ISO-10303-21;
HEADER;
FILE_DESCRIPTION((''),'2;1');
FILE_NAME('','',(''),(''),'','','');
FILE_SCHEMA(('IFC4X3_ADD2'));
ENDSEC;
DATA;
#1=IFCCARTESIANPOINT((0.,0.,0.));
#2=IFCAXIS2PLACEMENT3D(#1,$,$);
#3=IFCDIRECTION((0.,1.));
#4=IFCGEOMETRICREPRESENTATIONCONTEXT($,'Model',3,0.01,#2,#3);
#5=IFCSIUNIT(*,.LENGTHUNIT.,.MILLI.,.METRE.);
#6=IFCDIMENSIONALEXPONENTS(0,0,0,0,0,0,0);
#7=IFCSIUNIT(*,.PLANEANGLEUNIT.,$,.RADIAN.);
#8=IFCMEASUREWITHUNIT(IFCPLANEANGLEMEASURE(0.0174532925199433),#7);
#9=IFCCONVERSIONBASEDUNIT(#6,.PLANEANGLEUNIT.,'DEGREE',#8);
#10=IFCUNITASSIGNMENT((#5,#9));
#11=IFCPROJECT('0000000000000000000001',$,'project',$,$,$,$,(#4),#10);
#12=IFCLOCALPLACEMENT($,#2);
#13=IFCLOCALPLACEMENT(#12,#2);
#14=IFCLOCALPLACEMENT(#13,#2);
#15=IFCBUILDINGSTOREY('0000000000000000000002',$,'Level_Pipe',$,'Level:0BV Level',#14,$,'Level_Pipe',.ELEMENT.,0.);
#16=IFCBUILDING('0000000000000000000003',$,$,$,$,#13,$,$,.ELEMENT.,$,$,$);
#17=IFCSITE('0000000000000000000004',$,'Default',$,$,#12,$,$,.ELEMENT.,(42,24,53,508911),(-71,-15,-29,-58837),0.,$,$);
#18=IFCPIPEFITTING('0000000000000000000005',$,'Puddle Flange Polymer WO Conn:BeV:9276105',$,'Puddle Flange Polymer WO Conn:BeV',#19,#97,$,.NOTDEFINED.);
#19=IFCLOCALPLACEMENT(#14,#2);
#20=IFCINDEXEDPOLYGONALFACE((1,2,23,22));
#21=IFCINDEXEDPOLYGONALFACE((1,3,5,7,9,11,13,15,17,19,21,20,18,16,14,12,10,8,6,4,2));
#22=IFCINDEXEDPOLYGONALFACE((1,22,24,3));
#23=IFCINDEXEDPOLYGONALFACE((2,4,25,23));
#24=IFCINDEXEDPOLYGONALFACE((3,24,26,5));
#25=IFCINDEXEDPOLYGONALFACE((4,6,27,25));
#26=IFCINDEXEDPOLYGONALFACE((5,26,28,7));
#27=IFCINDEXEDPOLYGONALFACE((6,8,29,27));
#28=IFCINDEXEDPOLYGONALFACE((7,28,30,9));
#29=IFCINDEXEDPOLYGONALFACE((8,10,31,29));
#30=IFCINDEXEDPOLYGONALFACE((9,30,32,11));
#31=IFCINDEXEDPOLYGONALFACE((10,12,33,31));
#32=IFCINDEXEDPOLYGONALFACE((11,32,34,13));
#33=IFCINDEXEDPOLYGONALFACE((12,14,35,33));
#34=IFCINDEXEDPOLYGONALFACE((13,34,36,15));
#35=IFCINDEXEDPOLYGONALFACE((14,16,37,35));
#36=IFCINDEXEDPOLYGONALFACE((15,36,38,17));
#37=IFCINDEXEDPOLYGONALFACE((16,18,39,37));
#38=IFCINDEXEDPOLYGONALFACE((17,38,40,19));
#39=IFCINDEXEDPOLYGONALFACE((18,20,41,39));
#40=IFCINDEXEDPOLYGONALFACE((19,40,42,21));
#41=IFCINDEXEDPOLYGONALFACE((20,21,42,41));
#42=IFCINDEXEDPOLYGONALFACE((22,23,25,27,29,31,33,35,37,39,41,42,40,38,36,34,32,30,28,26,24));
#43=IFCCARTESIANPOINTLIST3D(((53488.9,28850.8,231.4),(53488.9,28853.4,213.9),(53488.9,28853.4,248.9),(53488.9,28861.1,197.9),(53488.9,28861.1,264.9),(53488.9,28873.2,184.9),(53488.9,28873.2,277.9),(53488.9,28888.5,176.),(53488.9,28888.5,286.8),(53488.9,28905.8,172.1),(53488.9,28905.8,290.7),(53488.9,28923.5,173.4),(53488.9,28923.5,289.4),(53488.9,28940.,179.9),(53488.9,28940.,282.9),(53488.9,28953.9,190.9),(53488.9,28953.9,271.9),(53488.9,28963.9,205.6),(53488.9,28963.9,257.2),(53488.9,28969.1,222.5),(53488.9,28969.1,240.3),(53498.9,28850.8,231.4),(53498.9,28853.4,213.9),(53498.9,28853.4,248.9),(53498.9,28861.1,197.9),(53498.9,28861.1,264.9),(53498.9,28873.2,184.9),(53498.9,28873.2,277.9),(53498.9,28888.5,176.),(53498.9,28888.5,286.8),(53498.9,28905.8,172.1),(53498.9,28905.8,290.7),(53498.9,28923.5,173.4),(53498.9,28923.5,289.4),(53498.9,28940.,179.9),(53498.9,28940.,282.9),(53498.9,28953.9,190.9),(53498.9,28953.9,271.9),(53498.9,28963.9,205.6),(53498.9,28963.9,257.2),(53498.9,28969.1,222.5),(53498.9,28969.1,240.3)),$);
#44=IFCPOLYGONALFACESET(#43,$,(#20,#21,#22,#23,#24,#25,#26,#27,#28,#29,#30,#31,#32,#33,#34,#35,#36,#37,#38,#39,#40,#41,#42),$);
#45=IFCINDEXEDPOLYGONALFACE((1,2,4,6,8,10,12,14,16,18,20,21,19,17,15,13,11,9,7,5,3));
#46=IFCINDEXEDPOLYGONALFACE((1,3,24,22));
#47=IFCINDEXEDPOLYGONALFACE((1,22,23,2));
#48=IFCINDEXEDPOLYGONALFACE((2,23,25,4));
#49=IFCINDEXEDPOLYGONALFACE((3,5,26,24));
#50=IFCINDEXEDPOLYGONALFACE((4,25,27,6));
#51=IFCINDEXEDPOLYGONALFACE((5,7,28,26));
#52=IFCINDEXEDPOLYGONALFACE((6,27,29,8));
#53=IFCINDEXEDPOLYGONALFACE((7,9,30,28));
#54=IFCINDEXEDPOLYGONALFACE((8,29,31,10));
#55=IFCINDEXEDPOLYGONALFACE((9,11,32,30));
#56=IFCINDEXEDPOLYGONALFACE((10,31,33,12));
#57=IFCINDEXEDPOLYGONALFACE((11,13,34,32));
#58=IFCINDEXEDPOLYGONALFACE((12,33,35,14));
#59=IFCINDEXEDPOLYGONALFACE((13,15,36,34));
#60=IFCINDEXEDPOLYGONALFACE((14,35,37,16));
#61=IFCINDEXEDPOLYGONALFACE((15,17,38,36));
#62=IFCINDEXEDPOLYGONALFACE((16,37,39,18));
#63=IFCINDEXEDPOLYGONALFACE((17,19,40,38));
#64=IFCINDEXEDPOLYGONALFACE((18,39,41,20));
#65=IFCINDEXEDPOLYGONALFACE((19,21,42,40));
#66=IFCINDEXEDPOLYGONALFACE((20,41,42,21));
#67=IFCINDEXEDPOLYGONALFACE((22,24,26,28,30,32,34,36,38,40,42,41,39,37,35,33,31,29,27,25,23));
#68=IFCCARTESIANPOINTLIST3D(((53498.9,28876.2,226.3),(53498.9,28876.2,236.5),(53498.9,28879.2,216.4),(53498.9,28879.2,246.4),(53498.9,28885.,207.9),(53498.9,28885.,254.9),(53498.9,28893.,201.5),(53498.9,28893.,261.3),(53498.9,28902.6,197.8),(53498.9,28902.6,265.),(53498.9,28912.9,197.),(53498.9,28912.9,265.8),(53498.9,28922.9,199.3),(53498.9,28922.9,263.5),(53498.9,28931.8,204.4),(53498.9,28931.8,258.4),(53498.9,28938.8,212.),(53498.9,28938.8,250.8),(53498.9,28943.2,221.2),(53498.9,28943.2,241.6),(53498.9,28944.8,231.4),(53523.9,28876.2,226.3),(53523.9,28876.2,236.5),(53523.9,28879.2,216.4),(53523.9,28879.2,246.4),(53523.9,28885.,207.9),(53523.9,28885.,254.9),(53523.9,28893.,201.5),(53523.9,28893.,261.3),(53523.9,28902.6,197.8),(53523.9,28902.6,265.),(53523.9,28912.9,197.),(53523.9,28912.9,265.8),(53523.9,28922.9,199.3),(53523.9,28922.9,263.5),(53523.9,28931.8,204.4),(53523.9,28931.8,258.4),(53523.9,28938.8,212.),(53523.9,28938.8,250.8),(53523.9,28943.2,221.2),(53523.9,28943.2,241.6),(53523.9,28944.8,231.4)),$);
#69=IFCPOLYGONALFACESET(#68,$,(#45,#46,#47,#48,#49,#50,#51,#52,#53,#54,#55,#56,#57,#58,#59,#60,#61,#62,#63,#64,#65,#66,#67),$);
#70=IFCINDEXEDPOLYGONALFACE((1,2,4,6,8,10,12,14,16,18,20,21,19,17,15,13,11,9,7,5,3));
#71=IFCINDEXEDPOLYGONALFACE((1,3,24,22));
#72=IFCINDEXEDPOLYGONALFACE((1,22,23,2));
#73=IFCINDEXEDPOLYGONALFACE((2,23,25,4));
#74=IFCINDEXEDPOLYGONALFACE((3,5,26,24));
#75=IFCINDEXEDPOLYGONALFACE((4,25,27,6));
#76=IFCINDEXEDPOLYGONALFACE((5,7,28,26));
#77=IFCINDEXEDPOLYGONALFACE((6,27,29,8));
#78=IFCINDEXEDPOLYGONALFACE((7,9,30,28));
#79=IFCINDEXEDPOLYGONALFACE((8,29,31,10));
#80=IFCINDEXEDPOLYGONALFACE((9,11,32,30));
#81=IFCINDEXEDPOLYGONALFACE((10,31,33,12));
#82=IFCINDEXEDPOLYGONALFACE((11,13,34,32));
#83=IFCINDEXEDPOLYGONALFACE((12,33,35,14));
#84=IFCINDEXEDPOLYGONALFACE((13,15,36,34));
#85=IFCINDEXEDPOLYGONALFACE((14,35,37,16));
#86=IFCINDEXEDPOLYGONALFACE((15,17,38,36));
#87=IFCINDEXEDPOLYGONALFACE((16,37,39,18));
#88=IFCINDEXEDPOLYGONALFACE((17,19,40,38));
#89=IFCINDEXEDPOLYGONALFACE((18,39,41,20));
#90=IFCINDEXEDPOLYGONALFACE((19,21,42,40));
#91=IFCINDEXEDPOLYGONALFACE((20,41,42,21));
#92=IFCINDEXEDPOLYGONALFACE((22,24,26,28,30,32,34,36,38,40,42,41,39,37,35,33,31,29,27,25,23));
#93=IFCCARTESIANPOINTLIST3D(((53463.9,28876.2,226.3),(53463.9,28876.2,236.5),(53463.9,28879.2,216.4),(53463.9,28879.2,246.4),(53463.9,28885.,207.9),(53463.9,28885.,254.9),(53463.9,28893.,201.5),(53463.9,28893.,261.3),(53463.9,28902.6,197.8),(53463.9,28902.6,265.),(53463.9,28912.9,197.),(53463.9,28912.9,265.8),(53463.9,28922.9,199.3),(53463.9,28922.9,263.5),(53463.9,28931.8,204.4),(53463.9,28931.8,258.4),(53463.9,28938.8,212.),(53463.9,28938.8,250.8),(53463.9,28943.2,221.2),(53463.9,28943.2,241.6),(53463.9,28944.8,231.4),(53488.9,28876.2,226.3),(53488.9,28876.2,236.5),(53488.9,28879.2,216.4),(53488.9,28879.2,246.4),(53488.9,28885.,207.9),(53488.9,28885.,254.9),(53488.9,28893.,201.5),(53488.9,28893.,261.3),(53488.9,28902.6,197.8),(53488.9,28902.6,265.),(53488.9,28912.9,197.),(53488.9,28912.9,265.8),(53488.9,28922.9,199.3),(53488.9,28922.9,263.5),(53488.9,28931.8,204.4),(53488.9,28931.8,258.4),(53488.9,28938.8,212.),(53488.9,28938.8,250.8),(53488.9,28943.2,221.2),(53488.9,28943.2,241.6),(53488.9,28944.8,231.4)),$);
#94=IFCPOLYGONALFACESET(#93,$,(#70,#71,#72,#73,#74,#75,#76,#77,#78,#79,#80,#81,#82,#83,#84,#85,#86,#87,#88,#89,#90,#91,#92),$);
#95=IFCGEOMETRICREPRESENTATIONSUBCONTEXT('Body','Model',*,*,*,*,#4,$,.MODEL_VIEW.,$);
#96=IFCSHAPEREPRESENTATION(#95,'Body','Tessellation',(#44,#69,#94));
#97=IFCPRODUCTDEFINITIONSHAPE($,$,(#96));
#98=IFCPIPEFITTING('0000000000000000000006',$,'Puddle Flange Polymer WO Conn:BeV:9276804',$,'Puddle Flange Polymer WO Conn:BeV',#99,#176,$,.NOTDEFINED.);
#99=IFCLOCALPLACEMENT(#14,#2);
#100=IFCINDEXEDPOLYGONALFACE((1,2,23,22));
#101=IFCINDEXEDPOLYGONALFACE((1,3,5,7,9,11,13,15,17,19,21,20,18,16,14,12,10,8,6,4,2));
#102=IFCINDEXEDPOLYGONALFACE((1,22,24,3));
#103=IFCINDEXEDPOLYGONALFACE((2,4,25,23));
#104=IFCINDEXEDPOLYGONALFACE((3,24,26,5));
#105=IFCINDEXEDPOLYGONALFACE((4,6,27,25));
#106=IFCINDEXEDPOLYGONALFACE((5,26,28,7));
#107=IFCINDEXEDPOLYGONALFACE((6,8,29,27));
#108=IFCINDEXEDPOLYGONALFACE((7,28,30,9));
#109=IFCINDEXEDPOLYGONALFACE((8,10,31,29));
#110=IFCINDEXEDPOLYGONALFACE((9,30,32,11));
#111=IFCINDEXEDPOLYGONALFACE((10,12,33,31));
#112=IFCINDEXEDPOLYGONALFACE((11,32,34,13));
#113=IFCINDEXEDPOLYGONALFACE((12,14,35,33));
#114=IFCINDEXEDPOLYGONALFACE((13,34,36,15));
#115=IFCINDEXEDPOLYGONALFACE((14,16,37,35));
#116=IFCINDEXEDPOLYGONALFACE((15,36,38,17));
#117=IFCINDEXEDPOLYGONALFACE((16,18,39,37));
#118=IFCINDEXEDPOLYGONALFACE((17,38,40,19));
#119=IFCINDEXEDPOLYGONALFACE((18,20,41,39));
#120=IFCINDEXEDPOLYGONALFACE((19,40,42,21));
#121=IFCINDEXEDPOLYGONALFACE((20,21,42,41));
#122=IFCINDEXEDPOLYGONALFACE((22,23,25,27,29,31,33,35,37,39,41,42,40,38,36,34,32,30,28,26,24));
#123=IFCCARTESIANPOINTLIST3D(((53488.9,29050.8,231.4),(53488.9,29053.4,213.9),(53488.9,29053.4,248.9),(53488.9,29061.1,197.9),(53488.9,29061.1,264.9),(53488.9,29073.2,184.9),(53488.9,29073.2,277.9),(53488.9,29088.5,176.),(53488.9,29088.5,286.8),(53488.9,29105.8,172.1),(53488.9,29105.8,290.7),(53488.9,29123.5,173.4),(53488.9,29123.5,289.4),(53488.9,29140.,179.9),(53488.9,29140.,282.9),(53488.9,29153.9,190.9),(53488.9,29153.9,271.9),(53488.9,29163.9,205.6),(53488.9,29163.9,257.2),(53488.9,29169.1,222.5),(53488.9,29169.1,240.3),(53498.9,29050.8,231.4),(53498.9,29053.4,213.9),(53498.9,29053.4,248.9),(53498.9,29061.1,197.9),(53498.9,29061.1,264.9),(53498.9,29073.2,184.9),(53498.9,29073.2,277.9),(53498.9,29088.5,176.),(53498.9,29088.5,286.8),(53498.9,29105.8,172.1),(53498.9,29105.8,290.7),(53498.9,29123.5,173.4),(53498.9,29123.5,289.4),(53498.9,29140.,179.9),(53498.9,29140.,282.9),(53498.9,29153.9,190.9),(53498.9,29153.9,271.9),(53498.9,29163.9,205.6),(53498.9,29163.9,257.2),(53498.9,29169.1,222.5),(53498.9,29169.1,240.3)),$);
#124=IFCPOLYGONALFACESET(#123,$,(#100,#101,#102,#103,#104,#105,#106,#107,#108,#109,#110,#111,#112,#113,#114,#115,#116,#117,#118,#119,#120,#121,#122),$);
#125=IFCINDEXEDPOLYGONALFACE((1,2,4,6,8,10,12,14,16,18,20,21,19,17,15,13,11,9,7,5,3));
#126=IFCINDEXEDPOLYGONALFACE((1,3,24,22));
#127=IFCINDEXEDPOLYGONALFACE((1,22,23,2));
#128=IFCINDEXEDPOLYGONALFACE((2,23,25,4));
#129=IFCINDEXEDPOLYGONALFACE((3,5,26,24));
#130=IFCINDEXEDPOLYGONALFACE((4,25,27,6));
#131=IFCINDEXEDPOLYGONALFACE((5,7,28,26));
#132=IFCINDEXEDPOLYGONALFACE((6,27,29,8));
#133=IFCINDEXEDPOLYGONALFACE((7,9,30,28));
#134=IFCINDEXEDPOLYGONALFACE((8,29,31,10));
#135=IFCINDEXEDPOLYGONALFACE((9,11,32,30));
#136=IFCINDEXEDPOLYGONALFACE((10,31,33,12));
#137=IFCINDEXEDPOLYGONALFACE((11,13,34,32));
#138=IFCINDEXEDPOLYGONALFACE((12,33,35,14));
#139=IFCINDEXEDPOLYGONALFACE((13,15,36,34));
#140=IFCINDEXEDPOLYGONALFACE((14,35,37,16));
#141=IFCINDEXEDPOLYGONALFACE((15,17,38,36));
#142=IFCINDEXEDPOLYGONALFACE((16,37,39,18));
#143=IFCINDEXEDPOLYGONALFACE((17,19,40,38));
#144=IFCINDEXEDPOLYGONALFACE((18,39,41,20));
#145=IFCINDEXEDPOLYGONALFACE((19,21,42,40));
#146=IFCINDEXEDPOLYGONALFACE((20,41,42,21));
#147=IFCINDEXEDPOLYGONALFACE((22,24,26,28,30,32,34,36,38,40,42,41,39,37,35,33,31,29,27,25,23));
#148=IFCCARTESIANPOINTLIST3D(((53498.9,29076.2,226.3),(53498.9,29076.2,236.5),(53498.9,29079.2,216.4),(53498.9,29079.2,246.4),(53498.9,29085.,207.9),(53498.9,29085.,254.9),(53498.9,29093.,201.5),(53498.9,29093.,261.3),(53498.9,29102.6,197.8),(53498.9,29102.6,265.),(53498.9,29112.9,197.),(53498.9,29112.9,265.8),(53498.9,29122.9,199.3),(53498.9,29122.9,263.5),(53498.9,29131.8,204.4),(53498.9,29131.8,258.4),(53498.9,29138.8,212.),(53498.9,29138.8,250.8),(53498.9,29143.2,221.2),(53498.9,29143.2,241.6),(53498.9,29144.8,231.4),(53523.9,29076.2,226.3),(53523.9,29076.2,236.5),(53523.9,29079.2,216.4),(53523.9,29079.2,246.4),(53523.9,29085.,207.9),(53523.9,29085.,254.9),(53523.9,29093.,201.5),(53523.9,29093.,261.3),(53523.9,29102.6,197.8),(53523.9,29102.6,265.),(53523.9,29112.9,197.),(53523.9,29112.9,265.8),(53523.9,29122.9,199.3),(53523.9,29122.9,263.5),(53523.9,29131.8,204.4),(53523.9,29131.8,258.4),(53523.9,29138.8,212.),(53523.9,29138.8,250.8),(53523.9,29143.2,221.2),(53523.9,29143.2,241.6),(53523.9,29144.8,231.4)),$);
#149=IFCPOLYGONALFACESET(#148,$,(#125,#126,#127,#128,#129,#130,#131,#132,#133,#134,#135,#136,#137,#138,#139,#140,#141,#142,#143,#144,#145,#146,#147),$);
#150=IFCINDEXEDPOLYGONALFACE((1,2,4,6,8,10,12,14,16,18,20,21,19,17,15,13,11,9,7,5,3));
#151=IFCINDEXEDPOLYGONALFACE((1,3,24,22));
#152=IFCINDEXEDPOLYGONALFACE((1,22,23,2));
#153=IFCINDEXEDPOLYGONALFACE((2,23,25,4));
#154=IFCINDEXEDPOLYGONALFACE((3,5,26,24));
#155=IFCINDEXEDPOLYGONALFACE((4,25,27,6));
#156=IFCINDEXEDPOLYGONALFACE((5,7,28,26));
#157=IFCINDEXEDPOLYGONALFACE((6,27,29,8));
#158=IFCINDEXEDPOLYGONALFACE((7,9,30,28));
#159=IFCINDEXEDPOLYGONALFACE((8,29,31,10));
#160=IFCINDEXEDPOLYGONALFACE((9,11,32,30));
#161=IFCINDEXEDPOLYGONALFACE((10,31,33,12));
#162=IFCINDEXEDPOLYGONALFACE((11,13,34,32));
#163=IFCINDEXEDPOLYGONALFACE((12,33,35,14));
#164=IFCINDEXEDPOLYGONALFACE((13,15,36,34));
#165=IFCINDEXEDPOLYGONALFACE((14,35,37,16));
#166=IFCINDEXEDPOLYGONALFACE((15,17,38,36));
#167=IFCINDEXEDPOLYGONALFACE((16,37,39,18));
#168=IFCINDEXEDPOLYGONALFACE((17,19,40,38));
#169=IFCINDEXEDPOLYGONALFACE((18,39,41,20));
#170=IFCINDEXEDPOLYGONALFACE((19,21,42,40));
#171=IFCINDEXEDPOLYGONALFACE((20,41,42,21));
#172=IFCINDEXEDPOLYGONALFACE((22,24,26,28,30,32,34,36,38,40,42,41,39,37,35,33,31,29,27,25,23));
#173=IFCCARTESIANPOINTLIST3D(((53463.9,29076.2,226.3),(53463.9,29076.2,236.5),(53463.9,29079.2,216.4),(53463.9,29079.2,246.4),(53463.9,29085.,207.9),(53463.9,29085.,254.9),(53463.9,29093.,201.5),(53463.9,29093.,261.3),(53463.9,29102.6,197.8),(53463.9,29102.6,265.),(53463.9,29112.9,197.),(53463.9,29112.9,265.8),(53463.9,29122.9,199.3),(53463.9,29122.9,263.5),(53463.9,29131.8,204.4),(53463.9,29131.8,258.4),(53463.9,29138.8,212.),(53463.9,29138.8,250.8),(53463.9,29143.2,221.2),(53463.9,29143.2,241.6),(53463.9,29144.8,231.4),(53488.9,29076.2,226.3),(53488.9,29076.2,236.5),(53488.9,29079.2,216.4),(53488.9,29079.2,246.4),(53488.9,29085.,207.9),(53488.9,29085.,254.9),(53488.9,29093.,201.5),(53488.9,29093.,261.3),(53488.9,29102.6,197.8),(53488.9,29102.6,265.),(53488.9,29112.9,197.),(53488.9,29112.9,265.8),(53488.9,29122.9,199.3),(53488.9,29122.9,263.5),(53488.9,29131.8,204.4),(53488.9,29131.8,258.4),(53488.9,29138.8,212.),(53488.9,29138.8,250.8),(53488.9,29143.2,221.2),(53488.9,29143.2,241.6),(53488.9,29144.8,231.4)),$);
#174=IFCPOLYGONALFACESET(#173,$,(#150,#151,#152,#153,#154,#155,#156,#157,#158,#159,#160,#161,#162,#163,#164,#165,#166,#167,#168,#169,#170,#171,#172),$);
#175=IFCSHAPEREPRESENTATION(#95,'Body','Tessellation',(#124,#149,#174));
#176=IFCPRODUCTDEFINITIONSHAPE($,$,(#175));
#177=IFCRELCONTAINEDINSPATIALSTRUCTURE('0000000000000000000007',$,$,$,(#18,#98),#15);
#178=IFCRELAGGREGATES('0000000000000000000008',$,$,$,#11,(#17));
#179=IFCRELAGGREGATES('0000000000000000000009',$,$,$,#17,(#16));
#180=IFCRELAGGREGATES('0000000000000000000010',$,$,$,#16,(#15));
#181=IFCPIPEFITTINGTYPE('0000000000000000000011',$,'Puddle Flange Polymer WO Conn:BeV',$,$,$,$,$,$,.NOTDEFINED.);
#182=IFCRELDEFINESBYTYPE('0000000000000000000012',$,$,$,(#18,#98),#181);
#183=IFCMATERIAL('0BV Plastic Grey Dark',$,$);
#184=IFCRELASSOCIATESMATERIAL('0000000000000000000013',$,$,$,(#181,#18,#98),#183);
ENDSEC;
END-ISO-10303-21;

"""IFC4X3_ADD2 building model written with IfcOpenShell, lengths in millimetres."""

from ifc_helpers import new_model, entity, si_unit, converted_unit, direction, frame, frame_2d, origin, place, context, subcontext, project, spatial, circle, extrude, source, transform, mapped, material, type_object, type_shapes, element, save


model = new_model("IFC4X3_ADD2")

# Units and contexts
model_context = context("Model", 3, precision=0.01, world=origin(), true_north=direction((0.0, 1.0)))
body_context = subcontext(model_context, "Body", "Model", "MODEL_VIEW")
ifc_project = project(units=[si_unit("LENGTHUNIT", "METRE", prefix="MILLI"), converted_unit("PLANEANGLEUNIT", "DEGREE", entity("IfcPlaneAngleMeasure", 0.0174532925199433), si_unit("PLANEANGLEUNIT", "RADIAN"), dimensions=[0, 0, 0, 0, 0, 0, 0])], contexts=[model_context])

# Site, building, storey
site_placement = place(None, origin())
site = spatial("IfcSite", under=ifc_project, at=site_placement, Name="Default", CompositionType="ELEMENT", RefLatitude=(42, 24, 53, 508911), RefLongitude=(-71, -15, -29, -58837), RefElevation=0.0)
building_placement = place(site_placement, origin())
building = spatial("IfcBuilding", under=site, at=building_placement, CompositionType="ELEMENT")
storey_placement = place(building_placement, origin())
storey = spatial("IfcBuildingStorey", under=building, at=storey_placement, Name="Level_Pipe", ObjectType="Level:0BV Level", LongName="Level_Pipe", CompositionType="ELEMENT", Elevation=0.0)

# Pipe fittings
ifc_material_1 = material(Name="0BV Plastic Grey Dark")
pipe_fitting_type_1 = type_object("IfcPipeFittingType", Name="Puddle Flange Polymer WO Conn:BeV", PredefinedType="NOTDEFINED", material=ifc_material_1)
shared_shape_1 = source(origin(), body_context, "Body", "SweptSolid", [
    extrude(circle(Radius=59.5, at=frame_2d((0.0, 0.0), x_axis=(1.0, 0.0))), frame((-5.0, 0.0, 0.0), z_axis=(1.0, 0.0, 0.0), x_axis=(0.0, -1.0, 0.0)), (0.0, 0.0, 1.0), 10.0),
    extrude(circle(Radius=34.5, at=frame_2d((0.0, 0.0), x_axis=(1.0, 0.0))), frame((5.0, 0.0, 0.0), z_axis=(1.0, 0.0, 0.0), x_axis=(0.0, 1.0, 0.0)), (0.0, 0.0, 1.0), 25.0),
    extrude(circle(Radius=34.5, at=frame_2d((0.0, 0.0), x_axis=(1.0, 0.0))), frame((-30.0, 0.0, 0.0), z_axis=(1.0, 0.0, 0.0), x_axis=(0.0, 1.0, 0.0)), (0.0, 0.0, 1.0), 25.0),
])
type_shapes(pipe_fitting_type_1, [shared_shape_1])
for number, where, name in (
    (1, (53493.9, 28910.3, 231.4), "Puddle Flange Polymer WO Conn:BeV:9276105"),
    (2, (53493.9, 29110.3, 231.4), "Puddle Flange Polymer WO Conn:BeV:9276804"),
):
    element("IfcPipeFitting", number, at=place(storey_placement, frame(where)), inside=storey, type_object=pipe_fitting_type_1, material=ifc_material_1, Name=name, ObjectType="Puddle Flange Polymer WO Conn:BeV", PredefinedType="NOTDEFINED", context=body_context, shape_type="MappedRepresentation", body=[
        mapped(shared_shape_1, transform((0.0, 0.0, 0.0), scale=1.0)),
    ])

save(model, "model.ifc")
